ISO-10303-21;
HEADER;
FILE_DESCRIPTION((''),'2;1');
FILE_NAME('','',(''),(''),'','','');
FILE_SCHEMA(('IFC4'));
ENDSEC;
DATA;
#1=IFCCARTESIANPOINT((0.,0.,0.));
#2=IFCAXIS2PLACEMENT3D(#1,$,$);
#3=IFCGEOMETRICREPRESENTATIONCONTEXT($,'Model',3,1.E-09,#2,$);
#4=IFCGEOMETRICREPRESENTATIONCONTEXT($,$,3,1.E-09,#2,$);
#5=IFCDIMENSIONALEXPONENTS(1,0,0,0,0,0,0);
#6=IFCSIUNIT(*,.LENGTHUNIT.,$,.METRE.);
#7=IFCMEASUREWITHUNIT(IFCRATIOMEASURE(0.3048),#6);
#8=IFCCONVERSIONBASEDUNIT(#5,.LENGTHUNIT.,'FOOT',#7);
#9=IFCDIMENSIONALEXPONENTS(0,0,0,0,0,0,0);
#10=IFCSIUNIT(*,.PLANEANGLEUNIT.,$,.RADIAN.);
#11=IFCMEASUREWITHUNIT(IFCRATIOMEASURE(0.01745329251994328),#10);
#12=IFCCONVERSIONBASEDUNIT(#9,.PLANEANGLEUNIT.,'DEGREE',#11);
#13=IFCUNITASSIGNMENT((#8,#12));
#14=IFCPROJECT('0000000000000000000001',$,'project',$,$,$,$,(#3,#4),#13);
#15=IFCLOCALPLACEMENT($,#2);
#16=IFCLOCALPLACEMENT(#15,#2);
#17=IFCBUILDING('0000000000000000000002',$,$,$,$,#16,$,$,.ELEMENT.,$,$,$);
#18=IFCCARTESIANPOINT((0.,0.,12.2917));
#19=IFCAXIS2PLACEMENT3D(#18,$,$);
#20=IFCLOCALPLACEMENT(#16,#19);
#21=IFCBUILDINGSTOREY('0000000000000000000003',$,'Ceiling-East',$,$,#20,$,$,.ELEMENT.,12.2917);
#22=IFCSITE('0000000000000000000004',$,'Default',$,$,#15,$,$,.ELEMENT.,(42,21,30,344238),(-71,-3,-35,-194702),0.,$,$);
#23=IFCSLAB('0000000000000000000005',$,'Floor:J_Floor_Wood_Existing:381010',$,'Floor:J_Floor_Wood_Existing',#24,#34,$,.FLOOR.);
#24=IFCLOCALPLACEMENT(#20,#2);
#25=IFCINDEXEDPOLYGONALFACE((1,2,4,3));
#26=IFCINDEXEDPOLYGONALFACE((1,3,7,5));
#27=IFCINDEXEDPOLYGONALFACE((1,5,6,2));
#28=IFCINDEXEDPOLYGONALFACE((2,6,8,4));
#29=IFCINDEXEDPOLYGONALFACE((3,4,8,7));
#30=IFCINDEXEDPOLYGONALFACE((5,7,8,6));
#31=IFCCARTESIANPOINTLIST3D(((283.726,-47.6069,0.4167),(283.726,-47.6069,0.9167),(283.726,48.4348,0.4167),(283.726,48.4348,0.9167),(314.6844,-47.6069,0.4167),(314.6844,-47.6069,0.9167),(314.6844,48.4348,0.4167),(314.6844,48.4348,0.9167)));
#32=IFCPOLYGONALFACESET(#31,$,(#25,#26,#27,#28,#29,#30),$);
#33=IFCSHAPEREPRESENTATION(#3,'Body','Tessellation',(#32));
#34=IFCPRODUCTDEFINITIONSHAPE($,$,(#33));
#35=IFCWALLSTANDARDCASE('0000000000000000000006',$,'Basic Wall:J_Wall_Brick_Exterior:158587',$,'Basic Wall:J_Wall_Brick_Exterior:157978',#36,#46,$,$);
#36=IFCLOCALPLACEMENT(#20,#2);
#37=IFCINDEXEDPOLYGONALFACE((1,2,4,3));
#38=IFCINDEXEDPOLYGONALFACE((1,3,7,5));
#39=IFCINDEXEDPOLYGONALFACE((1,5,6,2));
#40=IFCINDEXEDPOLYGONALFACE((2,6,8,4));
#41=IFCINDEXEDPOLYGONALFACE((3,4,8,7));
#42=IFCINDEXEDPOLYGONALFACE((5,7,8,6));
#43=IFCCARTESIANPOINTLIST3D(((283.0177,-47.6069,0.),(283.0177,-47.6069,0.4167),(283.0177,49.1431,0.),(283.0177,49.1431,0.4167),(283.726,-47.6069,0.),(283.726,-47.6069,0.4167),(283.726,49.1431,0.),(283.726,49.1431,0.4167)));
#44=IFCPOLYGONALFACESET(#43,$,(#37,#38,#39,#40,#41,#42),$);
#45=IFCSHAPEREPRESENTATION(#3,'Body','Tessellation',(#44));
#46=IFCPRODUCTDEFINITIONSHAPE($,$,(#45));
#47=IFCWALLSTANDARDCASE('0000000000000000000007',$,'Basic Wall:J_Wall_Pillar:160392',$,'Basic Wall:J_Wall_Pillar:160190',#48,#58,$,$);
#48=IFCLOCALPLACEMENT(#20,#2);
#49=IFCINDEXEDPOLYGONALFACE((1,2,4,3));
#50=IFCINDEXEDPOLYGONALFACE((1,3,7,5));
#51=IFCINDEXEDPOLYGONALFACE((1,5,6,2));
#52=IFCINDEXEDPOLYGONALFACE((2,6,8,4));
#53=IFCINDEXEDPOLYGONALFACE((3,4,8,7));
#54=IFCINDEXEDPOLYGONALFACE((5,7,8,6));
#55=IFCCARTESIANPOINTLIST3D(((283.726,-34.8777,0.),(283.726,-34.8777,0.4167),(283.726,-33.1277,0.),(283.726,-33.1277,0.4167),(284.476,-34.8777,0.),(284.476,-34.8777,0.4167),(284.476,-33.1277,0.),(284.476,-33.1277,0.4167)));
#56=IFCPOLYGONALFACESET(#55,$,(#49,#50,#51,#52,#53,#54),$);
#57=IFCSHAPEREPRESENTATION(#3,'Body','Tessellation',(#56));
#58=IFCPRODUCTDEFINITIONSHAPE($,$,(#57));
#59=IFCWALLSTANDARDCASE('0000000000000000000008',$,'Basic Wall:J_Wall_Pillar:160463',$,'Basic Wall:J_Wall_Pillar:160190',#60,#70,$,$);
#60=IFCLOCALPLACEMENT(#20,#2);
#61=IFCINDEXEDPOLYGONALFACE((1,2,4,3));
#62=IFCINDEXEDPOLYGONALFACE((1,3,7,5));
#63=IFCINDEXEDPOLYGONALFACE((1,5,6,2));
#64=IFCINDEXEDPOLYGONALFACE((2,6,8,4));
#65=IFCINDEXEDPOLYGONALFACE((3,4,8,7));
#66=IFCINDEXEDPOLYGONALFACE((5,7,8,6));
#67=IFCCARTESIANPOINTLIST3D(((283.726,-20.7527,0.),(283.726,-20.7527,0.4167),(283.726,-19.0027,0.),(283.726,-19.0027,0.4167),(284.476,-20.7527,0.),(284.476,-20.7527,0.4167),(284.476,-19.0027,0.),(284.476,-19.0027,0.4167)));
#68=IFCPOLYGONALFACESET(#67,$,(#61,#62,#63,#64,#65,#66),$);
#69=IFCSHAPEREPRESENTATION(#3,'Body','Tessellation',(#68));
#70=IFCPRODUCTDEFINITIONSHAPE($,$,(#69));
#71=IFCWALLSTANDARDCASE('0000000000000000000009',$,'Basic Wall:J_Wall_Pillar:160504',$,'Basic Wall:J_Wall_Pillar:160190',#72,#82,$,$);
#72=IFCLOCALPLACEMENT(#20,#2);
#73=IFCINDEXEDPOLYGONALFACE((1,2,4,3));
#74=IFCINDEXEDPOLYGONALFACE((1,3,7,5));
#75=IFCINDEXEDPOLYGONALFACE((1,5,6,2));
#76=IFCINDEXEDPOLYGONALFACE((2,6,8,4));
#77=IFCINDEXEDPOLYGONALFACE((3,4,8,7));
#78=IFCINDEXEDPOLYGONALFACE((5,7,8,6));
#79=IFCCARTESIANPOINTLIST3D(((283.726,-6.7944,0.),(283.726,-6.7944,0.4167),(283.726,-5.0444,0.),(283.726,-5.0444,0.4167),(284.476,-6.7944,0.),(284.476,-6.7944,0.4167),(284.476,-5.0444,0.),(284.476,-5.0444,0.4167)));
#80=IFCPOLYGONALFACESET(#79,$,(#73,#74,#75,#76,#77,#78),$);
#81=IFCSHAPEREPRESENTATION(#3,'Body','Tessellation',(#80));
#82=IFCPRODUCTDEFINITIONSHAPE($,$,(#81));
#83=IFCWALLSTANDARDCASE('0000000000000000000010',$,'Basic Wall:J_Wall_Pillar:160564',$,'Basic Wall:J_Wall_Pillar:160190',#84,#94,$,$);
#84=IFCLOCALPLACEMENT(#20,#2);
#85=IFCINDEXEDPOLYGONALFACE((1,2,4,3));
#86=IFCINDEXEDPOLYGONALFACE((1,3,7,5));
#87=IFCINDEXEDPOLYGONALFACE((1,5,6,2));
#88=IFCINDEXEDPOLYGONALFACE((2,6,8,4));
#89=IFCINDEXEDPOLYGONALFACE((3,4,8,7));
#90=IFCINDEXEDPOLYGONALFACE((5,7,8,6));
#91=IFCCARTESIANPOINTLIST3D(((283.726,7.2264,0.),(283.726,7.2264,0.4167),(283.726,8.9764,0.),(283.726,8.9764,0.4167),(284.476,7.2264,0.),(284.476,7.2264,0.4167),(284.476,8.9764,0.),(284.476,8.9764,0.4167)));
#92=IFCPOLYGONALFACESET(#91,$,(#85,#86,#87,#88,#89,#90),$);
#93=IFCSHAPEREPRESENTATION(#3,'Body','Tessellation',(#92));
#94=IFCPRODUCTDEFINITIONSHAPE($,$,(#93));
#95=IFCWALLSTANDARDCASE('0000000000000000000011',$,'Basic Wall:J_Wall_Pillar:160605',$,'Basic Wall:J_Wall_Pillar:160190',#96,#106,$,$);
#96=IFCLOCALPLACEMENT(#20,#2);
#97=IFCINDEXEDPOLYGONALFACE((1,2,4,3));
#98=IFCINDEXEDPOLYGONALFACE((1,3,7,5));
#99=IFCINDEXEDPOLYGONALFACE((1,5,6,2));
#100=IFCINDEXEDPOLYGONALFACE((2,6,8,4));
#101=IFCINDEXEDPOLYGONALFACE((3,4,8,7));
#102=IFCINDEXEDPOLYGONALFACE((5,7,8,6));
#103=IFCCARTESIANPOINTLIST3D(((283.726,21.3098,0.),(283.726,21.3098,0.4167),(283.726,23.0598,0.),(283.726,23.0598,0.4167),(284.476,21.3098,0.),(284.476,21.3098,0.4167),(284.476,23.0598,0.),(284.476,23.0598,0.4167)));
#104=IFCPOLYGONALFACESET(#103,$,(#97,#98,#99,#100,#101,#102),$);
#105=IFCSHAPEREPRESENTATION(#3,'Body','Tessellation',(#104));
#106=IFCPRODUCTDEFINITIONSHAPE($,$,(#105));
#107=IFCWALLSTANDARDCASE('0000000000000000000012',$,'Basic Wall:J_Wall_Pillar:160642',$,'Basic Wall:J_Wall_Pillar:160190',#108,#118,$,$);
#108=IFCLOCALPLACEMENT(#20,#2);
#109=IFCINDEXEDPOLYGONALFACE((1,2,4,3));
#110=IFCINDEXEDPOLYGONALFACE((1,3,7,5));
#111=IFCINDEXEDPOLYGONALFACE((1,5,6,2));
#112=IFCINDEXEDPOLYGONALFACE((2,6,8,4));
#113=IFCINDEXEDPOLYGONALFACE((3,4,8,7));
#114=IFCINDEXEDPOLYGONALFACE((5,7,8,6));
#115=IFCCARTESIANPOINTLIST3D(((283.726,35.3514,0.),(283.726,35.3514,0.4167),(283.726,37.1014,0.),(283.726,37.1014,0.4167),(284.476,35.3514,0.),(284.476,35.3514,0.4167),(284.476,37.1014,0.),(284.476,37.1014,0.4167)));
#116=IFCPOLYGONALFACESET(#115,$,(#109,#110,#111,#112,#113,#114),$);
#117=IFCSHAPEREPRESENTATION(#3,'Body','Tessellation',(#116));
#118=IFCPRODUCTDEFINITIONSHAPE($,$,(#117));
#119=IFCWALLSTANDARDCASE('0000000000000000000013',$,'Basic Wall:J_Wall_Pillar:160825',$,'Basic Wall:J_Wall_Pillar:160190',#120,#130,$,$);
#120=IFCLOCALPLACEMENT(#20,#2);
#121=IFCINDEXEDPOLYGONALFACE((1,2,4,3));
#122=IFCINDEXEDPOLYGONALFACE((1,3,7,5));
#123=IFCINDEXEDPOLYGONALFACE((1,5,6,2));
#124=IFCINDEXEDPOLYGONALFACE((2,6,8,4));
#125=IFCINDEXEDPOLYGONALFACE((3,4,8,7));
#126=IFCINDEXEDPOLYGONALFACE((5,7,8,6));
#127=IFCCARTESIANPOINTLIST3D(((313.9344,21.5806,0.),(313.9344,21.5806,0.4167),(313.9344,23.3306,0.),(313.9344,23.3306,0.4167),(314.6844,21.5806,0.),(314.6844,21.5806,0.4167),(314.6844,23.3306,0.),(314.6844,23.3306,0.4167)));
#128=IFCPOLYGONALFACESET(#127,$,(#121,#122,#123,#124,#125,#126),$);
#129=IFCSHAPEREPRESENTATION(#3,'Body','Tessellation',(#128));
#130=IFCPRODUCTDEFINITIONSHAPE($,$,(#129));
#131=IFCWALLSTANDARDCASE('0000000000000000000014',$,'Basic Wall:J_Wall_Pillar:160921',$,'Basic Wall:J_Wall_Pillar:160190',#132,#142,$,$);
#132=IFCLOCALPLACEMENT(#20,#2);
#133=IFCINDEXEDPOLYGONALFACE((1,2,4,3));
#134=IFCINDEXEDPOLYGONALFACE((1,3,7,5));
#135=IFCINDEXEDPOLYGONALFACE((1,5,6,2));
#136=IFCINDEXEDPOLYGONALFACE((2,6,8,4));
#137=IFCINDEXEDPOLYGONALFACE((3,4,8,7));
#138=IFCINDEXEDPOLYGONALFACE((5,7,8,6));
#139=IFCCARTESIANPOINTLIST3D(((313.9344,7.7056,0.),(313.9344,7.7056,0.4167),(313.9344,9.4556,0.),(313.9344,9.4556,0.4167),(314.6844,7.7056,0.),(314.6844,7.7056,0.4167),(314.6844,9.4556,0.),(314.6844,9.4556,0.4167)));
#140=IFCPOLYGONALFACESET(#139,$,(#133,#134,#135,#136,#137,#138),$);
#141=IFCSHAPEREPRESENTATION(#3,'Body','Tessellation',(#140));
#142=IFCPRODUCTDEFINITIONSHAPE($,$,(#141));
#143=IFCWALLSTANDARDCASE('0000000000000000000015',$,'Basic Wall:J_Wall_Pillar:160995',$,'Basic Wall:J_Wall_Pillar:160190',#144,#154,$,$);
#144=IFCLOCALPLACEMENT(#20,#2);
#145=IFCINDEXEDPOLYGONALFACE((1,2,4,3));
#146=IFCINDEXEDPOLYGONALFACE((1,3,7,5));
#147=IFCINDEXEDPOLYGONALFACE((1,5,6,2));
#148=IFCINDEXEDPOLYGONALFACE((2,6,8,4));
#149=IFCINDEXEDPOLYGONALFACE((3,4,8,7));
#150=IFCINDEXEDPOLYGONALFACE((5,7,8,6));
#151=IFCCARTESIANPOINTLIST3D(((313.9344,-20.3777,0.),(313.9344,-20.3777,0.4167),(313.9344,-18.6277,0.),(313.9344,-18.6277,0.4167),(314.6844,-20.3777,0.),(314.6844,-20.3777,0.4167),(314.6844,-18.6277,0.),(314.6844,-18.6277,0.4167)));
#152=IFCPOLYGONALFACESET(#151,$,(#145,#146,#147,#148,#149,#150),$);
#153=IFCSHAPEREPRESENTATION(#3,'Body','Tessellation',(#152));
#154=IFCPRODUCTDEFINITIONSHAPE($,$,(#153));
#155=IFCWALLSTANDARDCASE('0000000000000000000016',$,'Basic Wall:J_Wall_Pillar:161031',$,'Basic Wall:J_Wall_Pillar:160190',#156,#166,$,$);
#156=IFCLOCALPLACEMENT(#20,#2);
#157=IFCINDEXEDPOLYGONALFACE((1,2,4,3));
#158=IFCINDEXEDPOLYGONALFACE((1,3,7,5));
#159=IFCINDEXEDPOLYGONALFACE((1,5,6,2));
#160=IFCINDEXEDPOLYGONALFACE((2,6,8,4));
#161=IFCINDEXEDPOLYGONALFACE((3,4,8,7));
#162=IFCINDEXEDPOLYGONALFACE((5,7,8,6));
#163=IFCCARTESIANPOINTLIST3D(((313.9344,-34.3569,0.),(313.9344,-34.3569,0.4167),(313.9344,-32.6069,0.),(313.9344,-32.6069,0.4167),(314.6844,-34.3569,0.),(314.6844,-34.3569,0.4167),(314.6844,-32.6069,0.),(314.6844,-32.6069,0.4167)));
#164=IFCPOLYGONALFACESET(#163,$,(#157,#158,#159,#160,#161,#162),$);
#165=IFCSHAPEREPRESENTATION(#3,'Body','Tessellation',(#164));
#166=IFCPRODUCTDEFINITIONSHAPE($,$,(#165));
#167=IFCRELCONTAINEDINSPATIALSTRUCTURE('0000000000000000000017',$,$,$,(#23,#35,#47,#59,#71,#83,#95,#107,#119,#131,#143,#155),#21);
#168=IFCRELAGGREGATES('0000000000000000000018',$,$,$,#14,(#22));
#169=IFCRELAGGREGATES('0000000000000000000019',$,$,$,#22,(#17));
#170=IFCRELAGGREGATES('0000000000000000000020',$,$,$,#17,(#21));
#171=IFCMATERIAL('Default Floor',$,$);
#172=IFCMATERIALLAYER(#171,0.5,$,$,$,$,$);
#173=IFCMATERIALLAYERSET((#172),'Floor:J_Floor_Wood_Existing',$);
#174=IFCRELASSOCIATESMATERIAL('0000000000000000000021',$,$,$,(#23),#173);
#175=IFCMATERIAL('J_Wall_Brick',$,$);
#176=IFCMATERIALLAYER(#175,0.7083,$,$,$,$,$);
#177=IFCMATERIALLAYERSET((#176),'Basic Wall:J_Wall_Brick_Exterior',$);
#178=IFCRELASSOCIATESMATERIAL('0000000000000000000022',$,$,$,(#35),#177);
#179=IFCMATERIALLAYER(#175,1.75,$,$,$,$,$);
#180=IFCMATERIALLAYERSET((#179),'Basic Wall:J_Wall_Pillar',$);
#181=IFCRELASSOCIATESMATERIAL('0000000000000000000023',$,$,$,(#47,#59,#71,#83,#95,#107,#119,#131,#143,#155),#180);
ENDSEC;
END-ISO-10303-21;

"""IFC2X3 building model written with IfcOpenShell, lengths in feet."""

from ifc_helpers import new_model, entity, si_unit, converted_unit, frame, frame_2d, origin, origin_2d_with_axis, place, context, project, spatial, rectangle, extrude, clip, halfspace, material, layer, layer_set, layer_usage, element, save


model = new_model("IFC2X3")

# Units and contexts
model_context = context("Model", 3, precision=1e-09, world=origin())
context_of_model = context(None, 3, precision=1e-09, world=origin())
ifc_project = project(units=[converted_unit("LENGTHUNIT", "FOOT", entity("IfcRatioMeasure", 0.3048), si_unit("LENGTHUNIT", "METRE"), dimensions=[1, 0, 0, 0, 0, 0, 0]), converted_unit("PLANEANGLEUNIT", "DEGREE", entity("IfcRatioMeasure", 0.01745329251994328), si_unit("PLANEANGLEUNIT", "RADIAN"), dimensions=[0, 0, 0, 0, 0, 0, 0])], contexts=[model_context, context_of_model])

# Site, building, storey
site_placement = place(None, origin())
site = spatial("IfcSite", under=ifc_project, at=site_placement, Name="Default", CompositionType="ELEMENT", RefLatitude=(42, 21, 30, 344238), RefLongitude=(-71, -3, -35, -194702), RefElevation=0.0)
building_placement = place(site_placement, origin())
building = spatial("IfcBuilding", under=site, at=building_placement, CompositionType="ELEMENT")
storey_placement = place(building_placement, frame((0.0, 0.0, 12.2917)))
storey = spatial("IfcBuildingStorey", under=building, at=storey_placement, Name="Ceiling-East", CompositionType="ELEMENT", Elevation=12.2917)

# Slab
ifc_material_1 = material(Name="Default Floor")
ifc_layer_1 = layer(ifc_material_1, 0.5)
ifc_layer_set_1 = layer_set([ifc_layer_1], Name="Floor:J_Floor_Wood_Existing")
ifc_layer_usage_1 = layer_usage(ifc_layer_set_1, "AXIS3", "POSITIVE", 0.0)
slab_placement = place(storey_placement, frame((283.726, -47.6069, 0.4167)))
element("IfcSlab", 1, at=slab_placement, inside=storey, material=ifc_layer_usage_1, Name="Floor:J_Floor_Wood_Existing:381010", ObjectType="Floor:J_Floor_Wood_Existing", PredefinedType="FLOOR", context=model_context, shape_type="SweptSolid", body=[
    extrude(rectangle(XDim=30.9583, YDim=96.0417, at=origin_2d_with_axis()), frame((15.4792, 48.0208, 0.5), z_axis=(0.0, 0.0, -1.0), x_axis=(-1.0, 0.0, 0.0)), (0.0, 0.0, 1.0), 0.5),
])

# Wall
ifc_material_2 = material(Name="J_Wall_Brick")
ifc_layer_2 = layer(ifc_material_2, 0.7083)
ifc_layer_set_2 = layer_set([ifc_layer_2], Name="Basic Wall:J_Wall_Brick_Exterior")
ifc_layer_usage_2 = layer_usage(ifc_layer_set_2, "AXIS2", "NEGATIVE", 0.3542)
wall_1_placement = place(storey_placement, frame((283.3719, -47.6069, 0.0), z_axis=(0.0, 0.0, 1.0), x_axis=(0.0, 1.0, 0.0)))
element("IfcWallStandardCase", 2, at=wall_1_placement, inside=storey, material=ifc_layer_usage_2, Name="Basic Wall:J_Wall_Brick_Exterior:158587", ObjectType="Basic Wall:J_Wall_Brick_Exterior:157978", context=model_context, shape_type="Clipping", body=[
    clip(extrude(rectangle(XDim=96.75, YDim=0.7083, at=frame_2d((48.375, 0.0), x_axis=(-1.0, 0.0))), origin(), (0.0, 0.0, 1.0), 0.4167), halfspace(frame((0.0, 0.0, -12.125)), True)),
])

# Walls
ifc_layer_3 = layer(ifc_material_2, 1.75)
ifc_layer_set_3 = layer_set([ifc_layer_3], Name="Basic Wall:J_Wall_Pillar")
ifc_layer_usage_3 = layer_usage(ifc_layer_set_3, "AXIS2", "NEGATIVE", 0.875)
wall_2_placement = place(storey_placement, frame((283.726, -34.0027, 0.0)))
element("IfcWallStandardCase", 3, at=wall_2_placement, inside=storey, material=ifc_layer_usage_3, Name="Basic Wall:J_Wall_Pillar:160392", ObjectType="Basic Wall:J_Wall_Pillar:160190", context=model_context, shape_type="Clipping", body=[
    clip(extrude(rectangle(XDim=0.75, YDim=1.75, at=frame_2d((0.375, 0.0), x_axis=(-1.0, 0.0))), origin(), (0.0, 0.0, 1.0), 0.4167), halfspace(frame((0.0, 0.0, -12.125)), True)),
])
ifc_layer_usage_4 = layer_usage(ifc_layer_set_3, "AXIS2", "NEGATIVE", 0.875)
wall_3_placement = place(storey_placement, frame((283.726, -19.8777, 0.0)))
element("IfcWallStandardCase", 4, at=wall_3_placement, inside=storey, material=ifc_layer_usage_4, Name="Basic Wall:J_Wall_Pillar:160463", ObjectType="Basic Wall:J_Wall_Pillar:160190", context=model_context, shape_type="Clipping", body=[
    clip(extrude(rectangle(XDim=0.75, YDim=1.75, at=frame_2d((0.375, 0.0), x_axis=(-1.0, 0.0))), origin(), (0.0, 0.0, 1.0), 0.4167), halfspace(frame((0.0, 0.0, -12.125)), True)),
])
ifc_layer_usage_5 = layer_usage(ifc_layer_set_3, "AXIS2", "NEGATIVE", 0.875)
wall_4_placement = place(storey_placement, frame((283.726, -5.9194, 0.0)))
element("IfcWallStandardCase", 5, at=wall_4_placement, inside=storey, material=ifc_layer_usage_5, Name="Basic Wall:J_Wall_Pillar:160504", ObjectType="Basic Wall:J_Wall_Pillar:160190", context=model_context, shape_type="Clipping", body=[
    clip(extrude(rectangle(XDim=0.75, YDim=1.75, at=frame_2d((0.375, 0.0), x_axis=(-1.0, 0.0))), origin(), (0.0, 0.0, 1.0), 0.4167), halfspace(frame((0.0, 0.0, -12.125)), True)),
])
ifc_layer_usage_6 = layer_usage(ifc_layer_set_3, "AXIS2", "NEGATIVE", 0.875)
wall_5_placement = place(storey_placement, frame((283.726, 8.1014, 0.0)))
element("IfcWallStandardCase", 6, at=wall_5_placement, inside=storey, material=ifc_layer_usage_6, Name="Basic Wall:J_Wall_Pillar:160564", ObjectType="Basic Wall:J_Wall_Pillar:160190", context=model_context, shape_type="Clipping", body=[
    clip(extrude(rectangle(XDim=0.75, YDim=1.75, at=frame_2d((0.375, 0.0), x_axis=(-1.0, 0.0))), origin(), (0.0, 0.0, 1.0), 0.4167), halfspace(frame((0.0, 0.0, -12.125)), True)),
])
ifc_layer_usage_7 = layer_usage(ifc_layer_set_3, "AXIS2", "NEGATIVE", 0.875)
wall_6_placement = place(storey_placement, frame((283.726, 22.1848, 0.0)))
element("IfcWallStandardCase", 7, at=wall_6_placement, inside=storey, material=ifc_layer_usage_7, Name="Basic Wall:J_Wall_Pillar:160605", ObjectType="Basic Wall:J_Wall_Pillar:160190", context=model_context, shape_type="Clipping", body=[
    clip(extrude(rectangle(XDim=0.75, YDim=1.75, at=frame_2d((0.375, 0.0), x_axis=(-1.0, 0.0))), origin(), (0.0, 0.0, 1.0), 0.4167), halfspace(frame((0.0, 0.0, -12.125)), True)),
])
ifc_layer_usage_8 = layer_usage(ifc_layer_set_3, "AXIS2", "NEGATIVE", 0.875)
wall_7_placement = place(storey_placement, frame((283.726, 36.2264, 0.0)))
element("IfcWallStandardCase", 8, at=wall_7_placement, inside=storey, material=ifc_layer_usage_8, Name="Basic Wall:J_Wall_Pillar:160642", ObjectType="Basic Wall:J_Wall_Pillar:160190", context=model_context, shape_type="Clipping", body=[
    clip(extrude(rectangle(XDim=0.75, YDim=1.75, at=frame_2d((0.375, 0.0), x_axis=(-1.0, 0.0))), origin(), (0.0, 0.0, 1.0), 0.4167), halfspace(frame((0.0, 0.0, -12.125)), True)),
])
ifc_layer_usage_9 = layer_usage(ifc_layer_set_3, "AXIS2", "NEGATIVE", 0.875)
wall_8_placement = place(storey_placement, frame((314.6844, 22.4556, 0.0), z_axis=(0.0, 0.0, 1.0), x_axis=(-1.0, 0.0, 0.0)))
element("IfcWallStandardCase", 9, at=wall_8_placement, inside=storey, material=ifc_layer_usage_9, Name="Basic Wall:J_Wall_Pillar:160825", ObjectType="Basic Wall:J_Wall_Pillar:160190", context=model_context, shape_type="Clipping", body=[
    clip(extrude(rectangle(XDim=0.75, YDim=1.75, at=frame_2d((0.375, 0.0), x_axis=(-1.0, 0.0))), origin(), (0.0, 0.0, 1.0), 0.4167), halfspace(frame((0.0, 0.0, -12.125)), True)),
])
ifc_layer_usage_10 = layer_usage(ifc_layer_set_3, "AXIS2", "NEGATIVE", 0.875)
wall_9_placement = place(storey_placement, frame((314.6844, 8.5806, 0.0), z_axis=(0.0, 0.0, 1.0), x_axis=(-1.0, 0.0, 0.0)))
element("IfcWallStandardCase", 10, at=wall_9_placement, inside=storey, material=ifc_layer_usage_10, Name="Basic Wall:J_Wall_Pillar:160921", ObjectType="Basic Wall:J_Wall_Pillar:160190", context=model_context, shape_type="Clipping", body=[
    clip(extrude(rectangle(XDim=0.75, YDim=1.75, at=frame_2d((0.375, 0.0), x_axis=(-1.0, 0.0))), origin(), (0.0, 0.0, 1.0), 0.4167), halfspace(frame((0.0, 0.0, -12.125)), True)),
])
ifc_layer_usage_11 = layer_usage(ifc_layer_set_3, "AXIS2", "NEGATIVE", 0.875)
wall_10_placement = place(storey_placement, frame((314.6844, -19.5027, 0.0), z_axis=(0.0, 0.0, 1.0), x_axis=(-1.0, 0.0, 0.0)))
element("IfcWallStandardCase", 11, at=wall_10_placement, inside=storey, material=ifc_layer_usage_11, Name="Basic Wall:J_Wall_Pillar:160995", ObjectType="Basic Wall:J_Wall_Pillar:160190", context=model_context, shape_type="Clipping", body=[
    clip(extrude(rectangle(XDim=0.75, YDim=1.75, at=frame_2d((0.375, 0.0), x_axis=(-1.0, 0.0))), origin(), (0.0, 0.0, 1.0), 0.4167), halfspace(frame((0.0, 0.0, -12.125)), True)),
])
ifc_layer_usage_12 = layer_usage(ifc_layer_set_3, "AXIS2", "NEGATIVE", 0.875)
wall_11_placement = place(storey_placement, frame((314.6844, -33.4819, 0.0), z_axis=(0.0, 0.0, 1.0), x_axis=(-1.0, 0.0, 0.0)))
element("IfcWallStandardCase", 12, at=wall_11_placement, inside=storey, material=ifc_layer_usage_12, Name="Basic Wall:J_Wall_Pillar:161031", ObjectType="Basic Wall:J_Wall_Pillar:160190", context=model_context, shape_type="Clipping", body=[
    clip(extrude(rectangle(XDim=0.75, YDim=1.75, at=frame_2d((0.375, 0.0), x_axis=(-1.0, 0.0))), origin(), (0.0, 0.0, 1.0), 0.4167), halfspace(frame((0.0, 0.0, -12.125)), True)),
])

save(model, "model.ifc")
